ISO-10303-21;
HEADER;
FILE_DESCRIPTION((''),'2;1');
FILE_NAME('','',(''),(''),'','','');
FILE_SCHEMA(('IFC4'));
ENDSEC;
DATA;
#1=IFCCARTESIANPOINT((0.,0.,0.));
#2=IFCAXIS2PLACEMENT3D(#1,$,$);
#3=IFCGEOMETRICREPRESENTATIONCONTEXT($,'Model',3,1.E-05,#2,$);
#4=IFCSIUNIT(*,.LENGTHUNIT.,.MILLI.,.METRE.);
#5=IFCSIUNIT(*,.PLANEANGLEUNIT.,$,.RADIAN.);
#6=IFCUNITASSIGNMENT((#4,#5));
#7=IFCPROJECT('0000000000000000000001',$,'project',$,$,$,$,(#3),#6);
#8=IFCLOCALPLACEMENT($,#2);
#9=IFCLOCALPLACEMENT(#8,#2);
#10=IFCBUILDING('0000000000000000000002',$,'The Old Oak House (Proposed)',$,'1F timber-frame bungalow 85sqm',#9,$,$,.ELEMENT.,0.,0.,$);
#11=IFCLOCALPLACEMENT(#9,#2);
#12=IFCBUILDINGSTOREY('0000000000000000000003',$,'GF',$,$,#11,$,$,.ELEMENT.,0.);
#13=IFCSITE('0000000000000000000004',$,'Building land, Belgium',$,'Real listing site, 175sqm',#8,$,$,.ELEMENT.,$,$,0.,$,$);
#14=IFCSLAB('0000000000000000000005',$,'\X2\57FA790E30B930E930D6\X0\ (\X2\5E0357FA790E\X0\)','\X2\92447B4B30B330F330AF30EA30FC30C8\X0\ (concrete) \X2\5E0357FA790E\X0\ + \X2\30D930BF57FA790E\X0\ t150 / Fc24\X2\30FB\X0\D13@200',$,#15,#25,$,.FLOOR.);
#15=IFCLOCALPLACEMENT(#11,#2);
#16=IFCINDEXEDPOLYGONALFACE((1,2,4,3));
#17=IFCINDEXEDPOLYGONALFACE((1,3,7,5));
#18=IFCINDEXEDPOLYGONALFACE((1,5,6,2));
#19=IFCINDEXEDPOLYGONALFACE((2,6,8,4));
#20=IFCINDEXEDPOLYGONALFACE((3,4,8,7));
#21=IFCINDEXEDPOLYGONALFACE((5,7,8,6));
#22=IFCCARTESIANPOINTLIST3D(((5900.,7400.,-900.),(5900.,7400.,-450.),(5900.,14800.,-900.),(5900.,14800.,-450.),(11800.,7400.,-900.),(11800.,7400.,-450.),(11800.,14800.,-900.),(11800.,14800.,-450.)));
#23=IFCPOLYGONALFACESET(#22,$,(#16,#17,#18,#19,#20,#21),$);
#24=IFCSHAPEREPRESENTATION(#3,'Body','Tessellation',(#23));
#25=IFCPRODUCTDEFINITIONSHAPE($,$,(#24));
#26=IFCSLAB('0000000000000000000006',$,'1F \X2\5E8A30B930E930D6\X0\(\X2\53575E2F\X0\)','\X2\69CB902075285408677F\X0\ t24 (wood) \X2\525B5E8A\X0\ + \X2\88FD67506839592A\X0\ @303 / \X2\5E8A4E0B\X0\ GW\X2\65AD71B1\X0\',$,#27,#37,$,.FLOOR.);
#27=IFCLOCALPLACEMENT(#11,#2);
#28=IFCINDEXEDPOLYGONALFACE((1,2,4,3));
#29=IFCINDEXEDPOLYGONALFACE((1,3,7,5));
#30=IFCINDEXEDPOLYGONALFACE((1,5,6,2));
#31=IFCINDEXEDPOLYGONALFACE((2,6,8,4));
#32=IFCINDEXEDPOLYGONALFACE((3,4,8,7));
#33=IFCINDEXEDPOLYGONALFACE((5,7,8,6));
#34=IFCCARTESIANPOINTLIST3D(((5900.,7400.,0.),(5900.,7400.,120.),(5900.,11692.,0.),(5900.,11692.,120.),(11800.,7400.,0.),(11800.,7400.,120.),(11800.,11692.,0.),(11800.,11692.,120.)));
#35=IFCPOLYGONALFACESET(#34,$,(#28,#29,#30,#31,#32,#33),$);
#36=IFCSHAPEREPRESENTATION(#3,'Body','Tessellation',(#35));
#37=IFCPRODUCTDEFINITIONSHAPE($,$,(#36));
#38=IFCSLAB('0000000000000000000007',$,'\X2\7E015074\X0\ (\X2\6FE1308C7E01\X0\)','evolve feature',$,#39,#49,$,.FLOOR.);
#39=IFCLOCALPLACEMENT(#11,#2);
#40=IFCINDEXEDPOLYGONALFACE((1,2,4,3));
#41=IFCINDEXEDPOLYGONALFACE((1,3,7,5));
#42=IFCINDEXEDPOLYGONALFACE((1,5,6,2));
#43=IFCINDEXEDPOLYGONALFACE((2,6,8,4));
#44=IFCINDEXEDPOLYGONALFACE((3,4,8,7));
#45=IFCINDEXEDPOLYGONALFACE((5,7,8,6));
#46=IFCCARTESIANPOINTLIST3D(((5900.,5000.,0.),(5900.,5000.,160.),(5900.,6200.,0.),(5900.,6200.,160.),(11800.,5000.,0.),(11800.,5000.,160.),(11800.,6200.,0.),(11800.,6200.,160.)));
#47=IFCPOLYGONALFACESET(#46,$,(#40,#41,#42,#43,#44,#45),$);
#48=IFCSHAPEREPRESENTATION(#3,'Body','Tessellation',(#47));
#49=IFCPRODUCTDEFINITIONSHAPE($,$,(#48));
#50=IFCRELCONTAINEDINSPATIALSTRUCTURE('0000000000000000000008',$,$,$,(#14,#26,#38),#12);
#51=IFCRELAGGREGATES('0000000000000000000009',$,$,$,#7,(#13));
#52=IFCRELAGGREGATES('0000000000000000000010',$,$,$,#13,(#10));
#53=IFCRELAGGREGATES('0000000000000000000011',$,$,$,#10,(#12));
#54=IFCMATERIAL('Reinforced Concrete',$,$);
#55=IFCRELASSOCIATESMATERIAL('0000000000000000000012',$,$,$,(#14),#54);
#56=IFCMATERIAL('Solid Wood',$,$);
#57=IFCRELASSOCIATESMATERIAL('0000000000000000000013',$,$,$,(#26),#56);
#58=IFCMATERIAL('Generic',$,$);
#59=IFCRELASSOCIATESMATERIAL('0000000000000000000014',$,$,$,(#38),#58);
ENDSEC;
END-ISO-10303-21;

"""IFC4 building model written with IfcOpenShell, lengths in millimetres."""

from ifc_helpers import new_model, si_unit, frame, frame_2d, origin, place, context, project, spatial, rectangle, extrude, material, element, save


model = new_model("IFC4")

# Units and contexts
model_context = context("Model", 3, precision=1e-05, world=origin())
ifc_project = project(units=[si_unit("LENGTHUNIT", "METRE", prefix="MILLI"), si_unit("PLANEANGLEUNIT", "RADIAN")], contexts=[model_context])

# Site, building, storey
site_placement = place(None, origin())
site = spatial("IfcSite", under=ifc_project, at=site_placement, Name="Building land, Belgium", ObjectType="Real listing site, 175sqm", CompositionType="ELEMENT", RefElevation=0.0)
building_placement = place(site_placement, origin())
building = spatial("IfcBuilding", under=site, at=building_placement, Name="The Old Oak House (Proposed)", ObjectType="1F timber-frame bungalow 85sqm", CompositionType="ELEMENT", ElevationOfRefHeight=0.0, ElevationOfTerrain=0.0)
storey_placement = place(building_placement, origin())
storey = spatial("IfcBuildingStorey", under=building, at=storey_placement, Name="GF", CompositionType="ELEMENT", Elevation=0.0)

# Slabs
ifc_material_1 = material(Name="Reinforced Concrete")
slab_1_placement = place(storey_placement, frame((2950.0, 3700.0, -450.0)))
element("IfcSlab", 1, at=slab_1_placement, inside=storey, material=ifc_material_1, Name="基礎スラブ (布基礎)", Description="鉄筋コンクリート (concrete) 布基礎 + ベタ基礎 t150 / Fc24・D13@200", PredefinedType="FLOOR", context=model_context, shape_type="SweptSolid", body=[
    extrude(rectangle(XDim=5900.0, YDim=7400.0, at=frame_2d((2950.0, 3700.0))), frame((2950.0, 3700.0, -450.0)), (0.0, 0.0, 1.0), 450.0),
])
ifc_material_2 = material(Name="Solid Wood")
slab_2_placement = place(storey_placement, frame((2950.0, 3700.0, 0.0)))
element("IfcSlab", 2, at=slab_2_placement, inside=storey, material=ifc_material_2, Name="1F 床スラブ(南帯)", Description="構造用合板 t24 (wood) 剛床 + 製材根太 @303 / 床下 GW断熱", PredefinedType="FLOOR", context=model_context, shape_type="SweptSolid", body=[
    extrude(rectangle(XDim=5900.0, YDim=4292.0, at=frame_2d((2950.0, 2146.0))), frame((2950.0, 3700.0, 0.0)), (0.0, 0.0, 1.0), 120.0),
])
ifc_material_3 = material(Name="Generic")
slab_3_placement = place(storey_placement, frame((2950.0, 2500.0, 0.0)))
element("IfcSlab", 3, at=slab_3_placement, inside=storey, material=ifc_material_3, Name="縁側 (濡れ縁)", Description="evolve feature", PredefinedType="FLOOR", context=model_context, shape_type="SweptSolid", body=[
    extrude(rectangle(XDim=5900.0, YDim=1200.0, at=frame_2d((2950.0, 600.0))), frame((2950.0, 2500.0, 0.0)), (0.0, 0.0, 1.0), 160.0),
])

save(model, "model.ifc")
